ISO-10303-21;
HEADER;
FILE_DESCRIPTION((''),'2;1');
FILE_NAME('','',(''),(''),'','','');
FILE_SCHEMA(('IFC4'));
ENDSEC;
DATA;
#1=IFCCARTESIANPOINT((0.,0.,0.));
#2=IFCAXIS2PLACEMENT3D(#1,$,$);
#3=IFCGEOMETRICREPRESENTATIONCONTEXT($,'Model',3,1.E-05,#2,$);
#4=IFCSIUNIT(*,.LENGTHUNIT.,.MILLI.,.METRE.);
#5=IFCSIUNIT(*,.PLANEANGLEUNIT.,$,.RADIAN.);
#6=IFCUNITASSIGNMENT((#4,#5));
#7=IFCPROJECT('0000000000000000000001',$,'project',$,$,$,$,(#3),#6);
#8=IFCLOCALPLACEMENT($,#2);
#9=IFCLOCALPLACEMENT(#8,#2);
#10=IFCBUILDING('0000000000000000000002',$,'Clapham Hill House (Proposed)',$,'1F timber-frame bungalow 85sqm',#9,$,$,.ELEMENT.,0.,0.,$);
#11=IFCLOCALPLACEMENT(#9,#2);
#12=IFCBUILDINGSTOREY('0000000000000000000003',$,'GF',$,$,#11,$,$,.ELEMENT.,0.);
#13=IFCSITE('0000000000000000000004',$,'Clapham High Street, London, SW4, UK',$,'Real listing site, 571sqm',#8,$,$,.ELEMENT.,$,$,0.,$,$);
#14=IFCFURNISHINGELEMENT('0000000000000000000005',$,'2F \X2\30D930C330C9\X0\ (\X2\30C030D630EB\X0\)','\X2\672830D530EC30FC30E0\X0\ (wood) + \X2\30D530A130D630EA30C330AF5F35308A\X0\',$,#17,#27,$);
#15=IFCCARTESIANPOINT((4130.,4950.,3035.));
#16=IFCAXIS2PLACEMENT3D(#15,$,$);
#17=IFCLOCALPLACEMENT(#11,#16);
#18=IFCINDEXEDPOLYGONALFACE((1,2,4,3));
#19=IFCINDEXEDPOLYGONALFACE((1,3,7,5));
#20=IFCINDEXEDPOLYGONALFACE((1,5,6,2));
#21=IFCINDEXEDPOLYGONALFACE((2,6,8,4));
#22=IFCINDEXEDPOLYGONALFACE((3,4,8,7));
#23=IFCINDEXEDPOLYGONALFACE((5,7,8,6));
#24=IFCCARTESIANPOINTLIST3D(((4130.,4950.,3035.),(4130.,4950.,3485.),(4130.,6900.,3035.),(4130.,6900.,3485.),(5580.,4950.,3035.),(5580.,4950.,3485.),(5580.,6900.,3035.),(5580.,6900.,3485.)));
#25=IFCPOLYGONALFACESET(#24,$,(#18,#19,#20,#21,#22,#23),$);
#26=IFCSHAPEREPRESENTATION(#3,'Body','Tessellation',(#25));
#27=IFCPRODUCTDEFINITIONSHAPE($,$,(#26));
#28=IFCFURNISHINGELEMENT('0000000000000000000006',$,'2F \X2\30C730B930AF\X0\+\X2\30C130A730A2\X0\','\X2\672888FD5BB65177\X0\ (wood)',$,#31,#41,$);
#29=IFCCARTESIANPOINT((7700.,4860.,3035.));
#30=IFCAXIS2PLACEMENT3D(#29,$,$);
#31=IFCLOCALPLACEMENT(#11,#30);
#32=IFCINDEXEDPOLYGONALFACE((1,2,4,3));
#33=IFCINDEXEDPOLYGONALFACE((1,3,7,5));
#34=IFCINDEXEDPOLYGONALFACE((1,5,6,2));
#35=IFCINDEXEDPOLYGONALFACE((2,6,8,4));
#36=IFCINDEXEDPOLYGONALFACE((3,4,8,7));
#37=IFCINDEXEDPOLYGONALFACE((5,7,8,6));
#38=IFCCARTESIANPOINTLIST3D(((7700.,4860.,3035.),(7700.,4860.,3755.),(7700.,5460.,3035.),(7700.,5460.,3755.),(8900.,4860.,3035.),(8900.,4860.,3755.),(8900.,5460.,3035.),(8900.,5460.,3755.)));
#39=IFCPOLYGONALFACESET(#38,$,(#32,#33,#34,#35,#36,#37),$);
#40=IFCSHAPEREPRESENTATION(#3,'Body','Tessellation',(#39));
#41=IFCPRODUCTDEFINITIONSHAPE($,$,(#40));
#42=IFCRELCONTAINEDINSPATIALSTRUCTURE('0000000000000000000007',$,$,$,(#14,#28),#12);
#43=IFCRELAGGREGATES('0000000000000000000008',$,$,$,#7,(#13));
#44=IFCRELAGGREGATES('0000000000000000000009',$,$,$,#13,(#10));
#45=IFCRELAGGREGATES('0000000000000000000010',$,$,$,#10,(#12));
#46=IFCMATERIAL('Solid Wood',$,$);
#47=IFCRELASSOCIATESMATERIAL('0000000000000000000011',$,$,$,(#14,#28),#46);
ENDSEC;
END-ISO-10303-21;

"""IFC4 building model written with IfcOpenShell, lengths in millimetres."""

from ifc_helpers import new_model, si_unit, frame, frame_2d, origin, place, context, project, spatial, rectangle, extrude, material, element, save


model = new_model("IFC4")

# Units and contexts
model_context = context("Model", 3, precision=1e-05, world=origin())
ifc_project = project(units=[si_unit("LENGTHUNIT", "METRE", prefix="MILLI"), si_unit("PLANEANGLEUNIT", "RADIAN")], contexts=[model_context])

# Site, building, storey
site_placement = place(None, origin())
site = spatial("IfcSite", under=ifc_project, at=site_placement, Name="Clapham High Street, London, SW4, UK", ObjectType="Real listing site, 571sqm", CompositionType="ELEMENT", RefElevation=0.0)
building_placement = place(site_placement, origin())
building = spatial("IfcBuilding", under=site, at=building_placement, Name="Clapham Hill House (Proposed)", ObjectType="1F timber-frame bungalow 85sqm", CompositionType="ELEMENT", ElevationOfRefHeight=0.0, ElevationOfTerrain=0.0)
storey_placement = place(building_placement, origin())
storey = spatial("IfcBuildingStorey", under=building, at=storey_placement, Name="GF", CompositionType="ELEMENT", Elevation=0.0)

# Shared definitions
ifc_material_1 = material(Name="Solid Wood")

# Furnishing elements
furnishing_1_placement = place(storey_placement, frame((4130.0, 4950.0, 3035.0)))
element("IfcFurnishingElement", 1, at=furnishing_1_placement, inside=storey, material=ifc_material_1, Name="2F ベッド (ダブル)", Description="木フレーム (wood) + ファブリック張り", context=model_context, shape_type="SweptSolid", body=[
    extrude(rectangle(XDim=1450.0, YDim=1950.0, at=frame_2d((725.0, 975.0))), frame((4130.0, 4950.0, 3035.0)), (0.0, 0.0, 1.0), 450.0),
])
furnishing_2_placement = place(storey_placement, frame((7700.0, 4860.0, 3035.0)))
element("IfcFurnishingElement", 2, at=furnishing_2_placement, inside=storey, material=ifc_material_1, Name="2F デスク+チェア", Description="木製家具 (wood)", context=model_context, shape_type="SweptSolid", body=[
    extrude(rectangle(XDim=1200.0, YDim=600.0, at=frame_2d((600.0, 300.0))), frame((7700.0, 4860.0, 3035.0)), (0.0, 0.0, 1.0), 720.0),
])

save(model, "model.ifc")
